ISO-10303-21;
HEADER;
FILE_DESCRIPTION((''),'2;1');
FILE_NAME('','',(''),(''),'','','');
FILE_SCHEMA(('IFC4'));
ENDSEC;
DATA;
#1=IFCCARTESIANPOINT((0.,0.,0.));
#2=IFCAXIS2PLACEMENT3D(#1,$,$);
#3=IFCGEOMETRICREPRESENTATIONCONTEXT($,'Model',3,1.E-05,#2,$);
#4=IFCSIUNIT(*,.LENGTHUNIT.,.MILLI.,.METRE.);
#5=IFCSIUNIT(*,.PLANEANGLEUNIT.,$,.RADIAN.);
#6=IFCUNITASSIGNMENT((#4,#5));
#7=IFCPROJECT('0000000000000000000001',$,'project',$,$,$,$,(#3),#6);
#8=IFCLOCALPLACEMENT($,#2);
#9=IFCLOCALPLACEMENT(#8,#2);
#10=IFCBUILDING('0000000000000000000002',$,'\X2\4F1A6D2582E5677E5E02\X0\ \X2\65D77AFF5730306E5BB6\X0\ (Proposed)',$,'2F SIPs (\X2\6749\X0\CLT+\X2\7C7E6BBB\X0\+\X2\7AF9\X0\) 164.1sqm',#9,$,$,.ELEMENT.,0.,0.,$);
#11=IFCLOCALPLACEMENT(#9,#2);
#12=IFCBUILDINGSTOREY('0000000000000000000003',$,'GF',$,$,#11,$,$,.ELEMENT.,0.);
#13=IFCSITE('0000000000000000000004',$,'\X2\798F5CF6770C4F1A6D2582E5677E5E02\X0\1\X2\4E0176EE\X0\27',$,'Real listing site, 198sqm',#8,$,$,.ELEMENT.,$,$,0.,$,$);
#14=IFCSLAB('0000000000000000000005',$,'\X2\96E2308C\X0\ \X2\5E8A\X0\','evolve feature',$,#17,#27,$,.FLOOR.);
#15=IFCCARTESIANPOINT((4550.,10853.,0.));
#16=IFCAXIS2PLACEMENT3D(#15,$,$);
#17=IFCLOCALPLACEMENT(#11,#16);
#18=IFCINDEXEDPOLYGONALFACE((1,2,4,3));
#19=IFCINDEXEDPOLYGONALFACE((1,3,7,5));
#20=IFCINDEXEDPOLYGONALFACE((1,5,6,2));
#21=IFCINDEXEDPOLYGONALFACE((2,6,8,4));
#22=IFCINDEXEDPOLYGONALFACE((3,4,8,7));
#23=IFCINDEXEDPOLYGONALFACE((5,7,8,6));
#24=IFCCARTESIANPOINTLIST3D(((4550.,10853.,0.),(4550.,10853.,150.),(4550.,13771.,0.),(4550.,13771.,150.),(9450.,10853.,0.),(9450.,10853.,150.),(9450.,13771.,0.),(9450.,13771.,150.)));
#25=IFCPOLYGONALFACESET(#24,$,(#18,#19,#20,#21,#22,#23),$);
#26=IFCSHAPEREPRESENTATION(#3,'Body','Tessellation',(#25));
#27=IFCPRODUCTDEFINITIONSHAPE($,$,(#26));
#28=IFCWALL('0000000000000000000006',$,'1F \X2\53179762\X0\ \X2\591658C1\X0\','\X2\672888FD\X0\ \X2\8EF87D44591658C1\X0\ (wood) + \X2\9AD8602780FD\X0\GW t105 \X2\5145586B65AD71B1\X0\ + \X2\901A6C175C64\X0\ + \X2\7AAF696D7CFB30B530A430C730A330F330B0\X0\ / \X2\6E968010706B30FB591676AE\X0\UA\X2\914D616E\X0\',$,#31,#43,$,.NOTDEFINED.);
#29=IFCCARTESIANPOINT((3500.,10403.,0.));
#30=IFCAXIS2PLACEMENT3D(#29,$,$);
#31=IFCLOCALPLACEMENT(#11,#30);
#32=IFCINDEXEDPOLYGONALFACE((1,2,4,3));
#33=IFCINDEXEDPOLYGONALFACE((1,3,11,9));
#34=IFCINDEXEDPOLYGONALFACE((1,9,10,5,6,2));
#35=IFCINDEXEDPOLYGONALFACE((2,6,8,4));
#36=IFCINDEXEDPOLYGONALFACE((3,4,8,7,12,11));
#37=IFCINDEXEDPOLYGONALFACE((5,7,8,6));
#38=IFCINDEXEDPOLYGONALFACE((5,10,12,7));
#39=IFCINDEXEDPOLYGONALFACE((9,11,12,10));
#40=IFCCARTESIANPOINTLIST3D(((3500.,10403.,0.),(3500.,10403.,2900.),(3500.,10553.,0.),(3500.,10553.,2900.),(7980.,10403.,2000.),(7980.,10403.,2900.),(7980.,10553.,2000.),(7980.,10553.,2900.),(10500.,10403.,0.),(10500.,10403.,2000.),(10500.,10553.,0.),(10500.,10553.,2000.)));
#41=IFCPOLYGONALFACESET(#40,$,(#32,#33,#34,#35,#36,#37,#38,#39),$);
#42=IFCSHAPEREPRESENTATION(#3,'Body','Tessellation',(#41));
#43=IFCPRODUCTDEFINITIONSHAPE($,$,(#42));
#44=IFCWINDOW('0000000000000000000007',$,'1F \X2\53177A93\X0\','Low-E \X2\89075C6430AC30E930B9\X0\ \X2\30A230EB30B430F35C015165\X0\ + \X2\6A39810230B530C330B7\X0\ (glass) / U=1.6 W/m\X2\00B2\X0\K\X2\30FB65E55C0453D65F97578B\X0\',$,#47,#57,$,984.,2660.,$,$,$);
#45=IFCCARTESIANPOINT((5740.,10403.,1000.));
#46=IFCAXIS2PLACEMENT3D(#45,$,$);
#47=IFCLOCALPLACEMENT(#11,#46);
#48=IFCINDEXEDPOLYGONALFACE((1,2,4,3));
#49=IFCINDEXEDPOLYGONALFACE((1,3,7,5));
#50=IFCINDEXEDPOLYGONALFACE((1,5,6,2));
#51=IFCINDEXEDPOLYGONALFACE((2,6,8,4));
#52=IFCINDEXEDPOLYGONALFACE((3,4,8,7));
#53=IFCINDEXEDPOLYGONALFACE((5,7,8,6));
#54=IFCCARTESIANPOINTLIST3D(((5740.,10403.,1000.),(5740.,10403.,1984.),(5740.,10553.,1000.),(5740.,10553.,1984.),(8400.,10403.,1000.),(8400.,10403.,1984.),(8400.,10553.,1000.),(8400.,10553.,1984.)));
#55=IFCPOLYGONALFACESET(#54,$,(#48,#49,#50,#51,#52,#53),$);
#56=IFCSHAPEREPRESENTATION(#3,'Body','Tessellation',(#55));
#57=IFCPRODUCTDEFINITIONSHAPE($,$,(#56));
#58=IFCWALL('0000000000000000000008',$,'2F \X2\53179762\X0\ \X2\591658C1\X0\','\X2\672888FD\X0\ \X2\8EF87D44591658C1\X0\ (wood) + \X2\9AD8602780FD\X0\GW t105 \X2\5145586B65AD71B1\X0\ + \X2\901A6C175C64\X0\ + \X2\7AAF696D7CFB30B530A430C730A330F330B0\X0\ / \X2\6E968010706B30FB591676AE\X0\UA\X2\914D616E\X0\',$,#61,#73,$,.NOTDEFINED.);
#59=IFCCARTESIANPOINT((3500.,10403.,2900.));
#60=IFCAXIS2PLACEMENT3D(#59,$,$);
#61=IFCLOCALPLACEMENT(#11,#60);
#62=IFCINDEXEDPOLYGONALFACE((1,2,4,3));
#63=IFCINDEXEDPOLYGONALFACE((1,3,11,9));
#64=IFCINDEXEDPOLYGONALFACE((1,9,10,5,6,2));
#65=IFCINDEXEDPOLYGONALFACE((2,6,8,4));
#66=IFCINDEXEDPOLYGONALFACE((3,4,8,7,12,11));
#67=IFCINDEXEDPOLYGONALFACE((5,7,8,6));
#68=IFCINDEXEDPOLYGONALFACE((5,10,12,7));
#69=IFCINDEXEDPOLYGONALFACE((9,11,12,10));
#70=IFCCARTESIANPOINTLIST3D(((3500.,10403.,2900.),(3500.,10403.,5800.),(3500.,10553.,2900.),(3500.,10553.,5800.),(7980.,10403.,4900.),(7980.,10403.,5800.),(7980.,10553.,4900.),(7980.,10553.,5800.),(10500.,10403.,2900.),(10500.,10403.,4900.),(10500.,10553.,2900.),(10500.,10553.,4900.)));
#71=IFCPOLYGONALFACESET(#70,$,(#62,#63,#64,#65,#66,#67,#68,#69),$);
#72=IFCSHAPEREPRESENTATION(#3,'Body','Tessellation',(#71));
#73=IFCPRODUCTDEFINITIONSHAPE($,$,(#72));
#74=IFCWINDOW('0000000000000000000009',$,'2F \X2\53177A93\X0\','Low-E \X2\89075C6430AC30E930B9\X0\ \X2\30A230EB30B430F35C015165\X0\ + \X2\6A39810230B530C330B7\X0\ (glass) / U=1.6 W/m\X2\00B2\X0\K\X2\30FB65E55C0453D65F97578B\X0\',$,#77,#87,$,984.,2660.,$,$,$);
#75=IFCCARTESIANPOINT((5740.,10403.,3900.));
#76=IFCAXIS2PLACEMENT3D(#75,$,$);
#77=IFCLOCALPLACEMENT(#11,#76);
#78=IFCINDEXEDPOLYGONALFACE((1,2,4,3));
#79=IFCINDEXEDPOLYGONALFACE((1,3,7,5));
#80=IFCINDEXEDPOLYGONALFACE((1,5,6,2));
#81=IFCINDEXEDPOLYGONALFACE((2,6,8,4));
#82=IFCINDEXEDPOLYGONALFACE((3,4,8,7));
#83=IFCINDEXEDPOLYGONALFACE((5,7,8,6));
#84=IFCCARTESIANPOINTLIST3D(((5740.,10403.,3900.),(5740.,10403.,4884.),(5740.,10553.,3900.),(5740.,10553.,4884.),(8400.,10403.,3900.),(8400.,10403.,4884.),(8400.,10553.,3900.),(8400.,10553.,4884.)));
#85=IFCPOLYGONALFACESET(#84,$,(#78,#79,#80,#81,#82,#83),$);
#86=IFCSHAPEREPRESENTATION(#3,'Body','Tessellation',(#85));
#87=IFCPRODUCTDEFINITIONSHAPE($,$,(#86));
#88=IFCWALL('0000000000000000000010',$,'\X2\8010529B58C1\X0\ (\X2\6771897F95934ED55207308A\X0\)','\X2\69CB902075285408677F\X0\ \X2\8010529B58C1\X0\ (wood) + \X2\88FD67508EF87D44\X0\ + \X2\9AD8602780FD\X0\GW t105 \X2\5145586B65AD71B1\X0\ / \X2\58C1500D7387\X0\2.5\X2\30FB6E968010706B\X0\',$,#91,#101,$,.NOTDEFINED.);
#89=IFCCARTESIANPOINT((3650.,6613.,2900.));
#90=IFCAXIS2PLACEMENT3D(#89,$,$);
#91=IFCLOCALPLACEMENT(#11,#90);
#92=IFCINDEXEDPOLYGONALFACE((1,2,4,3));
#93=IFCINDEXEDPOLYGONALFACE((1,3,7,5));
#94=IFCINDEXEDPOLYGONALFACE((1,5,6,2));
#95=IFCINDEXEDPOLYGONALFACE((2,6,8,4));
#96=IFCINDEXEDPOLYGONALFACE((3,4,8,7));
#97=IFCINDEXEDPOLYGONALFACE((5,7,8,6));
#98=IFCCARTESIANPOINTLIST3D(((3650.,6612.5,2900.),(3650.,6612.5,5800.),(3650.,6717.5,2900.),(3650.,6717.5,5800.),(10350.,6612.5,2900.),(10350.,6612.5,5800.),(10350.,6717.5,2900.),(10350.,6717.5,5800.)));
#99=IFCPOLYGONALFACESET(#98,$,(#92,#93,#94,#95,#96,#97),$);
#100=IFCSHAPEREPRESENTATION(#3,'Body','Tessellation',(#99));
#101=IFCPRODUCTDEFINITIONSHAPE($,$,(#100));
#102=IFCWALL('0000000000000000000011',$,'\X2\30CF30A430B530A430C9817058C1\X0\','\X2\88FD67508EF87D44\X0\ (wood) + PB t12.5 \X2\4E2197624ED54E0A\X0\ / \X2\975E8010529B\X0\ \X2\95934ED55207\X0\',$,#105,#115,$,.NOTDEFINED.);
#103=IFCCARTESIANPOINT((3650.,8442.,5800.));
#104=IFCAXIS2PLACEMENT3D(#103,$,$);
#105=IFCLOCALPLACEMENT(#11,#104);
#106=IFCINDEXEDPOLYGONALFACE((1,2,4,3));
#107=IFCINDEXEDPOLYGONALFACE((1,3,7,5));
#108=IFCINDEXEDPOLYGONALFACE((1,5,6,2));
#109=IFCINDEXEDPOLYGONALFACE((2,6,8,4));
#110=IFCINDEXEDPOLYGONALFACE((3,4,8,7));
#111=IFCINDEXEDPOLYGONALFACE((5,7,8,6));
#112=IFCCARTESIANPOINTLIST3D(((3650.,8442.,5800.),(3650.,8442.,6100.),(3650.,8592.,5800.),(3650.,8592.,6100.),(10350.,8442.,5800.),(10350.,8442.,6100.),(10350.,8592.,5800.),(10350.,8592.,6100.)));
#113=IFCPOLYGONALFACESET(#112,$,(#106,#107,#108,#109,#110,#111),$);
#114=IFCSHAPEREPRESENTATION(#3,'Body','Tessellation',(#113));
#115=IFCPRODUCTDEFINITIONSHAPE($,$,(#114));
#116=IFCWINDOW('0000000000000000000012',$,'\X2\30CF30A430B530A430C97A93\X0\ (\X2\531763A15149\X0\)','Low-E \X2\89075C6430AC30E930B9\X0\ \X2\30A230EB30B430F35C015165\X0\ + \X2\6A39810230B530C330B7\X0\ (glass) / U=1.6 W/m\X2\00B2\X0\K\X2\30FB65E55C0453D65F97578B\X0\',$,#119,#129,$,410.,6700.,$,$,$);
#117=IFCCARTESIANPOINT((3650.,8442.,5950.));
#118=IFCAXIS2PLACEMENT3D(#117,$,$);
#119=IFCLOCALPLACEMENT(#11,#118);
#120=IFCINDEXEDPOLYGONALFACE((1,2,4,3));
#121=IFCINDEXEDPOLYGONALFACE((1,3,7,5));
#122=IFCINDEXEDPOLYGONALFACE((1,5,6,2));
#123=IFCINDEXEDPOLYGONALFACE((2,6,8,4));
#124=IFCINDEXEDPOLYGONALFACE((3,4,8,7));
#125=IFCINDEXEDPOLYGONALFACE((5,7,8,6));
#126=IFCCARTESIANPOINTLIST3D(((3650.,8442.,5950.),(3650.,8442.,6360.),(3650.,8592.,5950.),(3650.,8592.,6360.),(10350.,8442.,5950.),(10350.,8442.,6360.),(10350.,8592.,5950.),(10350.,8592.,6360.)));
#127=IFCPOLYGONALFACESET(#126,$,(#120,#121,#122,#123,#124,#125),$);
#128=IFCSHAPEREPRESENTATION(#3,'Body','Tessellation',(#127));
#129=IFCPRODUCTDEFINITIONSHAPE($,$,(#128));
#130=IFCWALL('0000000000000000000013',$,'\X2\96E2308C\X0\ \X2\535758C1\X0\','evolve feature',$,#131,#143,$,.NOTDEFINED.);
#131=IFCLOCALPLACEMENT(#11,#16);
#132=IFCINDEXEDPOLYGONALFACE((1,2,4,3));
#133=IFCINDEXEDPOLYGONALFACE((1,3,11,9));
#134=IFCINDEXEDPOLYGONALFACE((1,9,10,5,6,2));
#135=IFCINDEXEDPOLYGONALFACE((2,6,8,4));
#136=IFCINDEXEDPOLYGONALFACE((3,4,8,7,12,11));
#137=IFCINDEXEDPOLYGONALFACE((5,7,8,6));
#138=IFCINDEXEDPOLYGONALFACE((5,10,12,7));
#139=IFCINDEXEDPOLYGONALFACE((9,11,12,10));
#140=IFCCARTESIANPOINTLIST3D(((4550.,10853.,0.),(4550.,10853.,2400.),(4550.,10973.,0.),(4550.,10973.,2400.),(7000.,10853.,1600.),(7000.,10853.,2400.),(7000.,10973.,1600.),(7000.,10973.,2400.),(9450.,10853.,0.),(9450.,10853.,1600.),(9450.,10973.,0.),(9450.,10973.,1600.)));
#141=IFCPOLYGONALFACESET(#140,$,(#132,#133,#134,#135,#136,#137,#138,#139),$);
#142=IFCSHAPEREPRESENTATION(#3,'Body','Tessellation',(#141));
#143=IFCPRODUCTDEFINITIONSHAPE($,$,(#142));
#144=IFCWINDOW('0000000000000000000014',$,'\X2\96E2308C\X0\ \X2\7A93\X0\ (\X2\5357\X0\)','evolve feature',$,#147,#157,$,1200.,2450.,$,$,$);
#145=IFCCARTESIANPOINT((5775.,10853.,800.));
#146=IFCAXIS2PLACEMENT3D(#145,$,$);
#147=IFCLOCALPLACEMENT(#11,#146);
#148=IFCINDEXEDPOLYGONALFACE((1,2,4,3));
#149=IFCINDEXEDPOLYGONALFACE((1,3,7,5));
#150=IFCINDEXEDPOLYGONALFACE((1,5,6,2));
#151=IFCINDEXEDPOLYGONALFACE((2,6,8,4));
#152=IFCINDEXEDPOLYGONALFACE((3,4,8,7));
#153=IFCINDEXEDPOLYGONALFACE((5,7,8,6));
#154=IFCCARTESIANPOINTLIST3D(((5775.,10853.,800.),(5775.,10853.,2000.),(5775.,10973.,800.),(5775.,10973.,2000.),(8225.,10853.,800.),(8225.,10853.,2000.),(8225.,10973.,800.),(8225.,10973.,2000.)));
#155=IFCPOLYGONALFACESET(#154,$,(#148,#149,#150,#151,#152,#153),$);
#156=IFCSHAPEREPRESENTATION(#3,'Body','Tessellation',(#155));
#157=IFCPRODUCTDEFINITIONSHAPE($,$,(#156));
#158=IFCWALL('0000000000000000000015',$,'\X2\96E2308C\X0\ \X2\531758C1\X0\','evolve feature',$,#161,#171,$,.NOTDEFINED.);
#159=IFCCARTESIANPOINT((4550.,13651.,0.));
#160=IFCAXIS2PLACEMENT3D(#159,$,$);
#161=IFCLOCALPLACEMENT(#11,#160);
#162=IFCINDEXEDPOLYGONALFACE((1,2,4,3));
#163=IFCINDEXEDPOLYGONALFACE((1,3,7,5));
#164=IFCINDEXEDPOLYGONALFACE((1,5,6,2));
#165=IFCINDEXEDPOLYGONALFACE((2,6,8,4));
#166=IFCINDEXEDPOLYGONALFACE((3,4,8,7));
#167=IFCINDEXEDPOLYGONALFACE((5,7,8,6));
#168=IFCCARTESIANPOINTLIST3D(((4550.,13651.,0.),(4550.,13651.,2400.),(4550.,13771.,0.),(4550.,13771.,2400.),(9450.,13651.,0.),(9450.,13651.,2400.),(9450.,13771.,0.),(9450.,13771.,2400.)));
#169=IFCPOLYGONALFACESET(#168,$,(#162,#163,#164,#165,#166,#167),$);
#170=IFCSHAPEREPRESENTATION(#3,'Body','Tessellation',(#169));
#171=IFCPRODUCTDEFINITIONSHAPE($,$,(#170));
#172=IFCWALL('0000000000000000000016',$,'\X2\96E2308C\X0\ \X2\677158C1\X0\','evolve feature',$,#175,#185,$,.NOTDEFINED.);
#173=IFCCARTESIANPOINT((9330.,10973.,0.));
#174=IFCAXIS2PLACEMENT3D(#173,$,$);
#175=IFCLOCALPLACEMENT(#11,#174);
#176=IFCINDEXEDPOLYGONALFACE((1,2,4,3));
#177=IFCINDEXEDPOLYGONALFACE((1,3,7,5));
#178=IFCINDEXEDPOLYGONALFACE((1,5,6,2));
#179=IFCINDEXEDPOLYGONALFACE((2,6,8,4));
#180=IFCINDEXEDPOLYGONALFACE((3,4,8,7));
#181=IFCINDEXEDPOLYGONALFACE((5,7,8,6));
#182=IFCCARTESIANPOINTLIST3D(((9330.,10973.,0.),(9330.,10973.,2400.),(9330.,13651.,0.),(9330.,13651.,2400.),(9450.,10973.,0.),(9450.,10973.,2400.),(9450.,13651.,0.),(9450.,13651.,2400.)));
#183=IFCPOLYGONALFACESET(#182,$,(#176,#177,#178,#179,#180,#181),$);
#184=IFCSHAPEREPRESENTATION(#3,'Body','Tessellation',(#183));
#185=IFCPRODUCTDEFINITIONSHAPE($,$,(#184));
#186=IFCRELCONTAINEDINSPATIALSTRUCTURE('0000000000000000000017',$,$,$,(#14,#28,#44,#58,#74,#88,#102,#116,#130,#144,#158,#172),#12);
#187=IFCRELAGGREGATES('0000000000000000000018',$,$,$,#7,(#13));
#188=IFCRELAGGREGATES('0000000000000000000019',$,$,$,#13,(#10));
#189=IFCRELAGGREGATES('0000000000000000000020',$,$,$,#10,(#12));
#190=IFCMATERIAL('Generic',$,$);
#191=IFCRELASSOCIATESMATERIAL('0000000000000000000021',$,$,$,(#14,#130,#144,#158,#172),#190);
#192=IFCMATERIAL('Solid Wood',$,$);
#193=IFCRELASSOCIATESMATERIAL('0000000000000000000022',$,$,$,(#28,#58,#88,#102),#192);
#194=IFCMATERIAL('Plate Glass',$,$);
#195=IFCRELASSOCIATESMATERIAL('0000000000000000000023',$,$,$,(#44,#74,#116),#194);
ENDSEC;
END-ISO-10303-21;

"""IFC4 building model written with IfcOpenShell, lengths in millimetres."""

from ifc_helpers import new_model, si_unit, frame, frame_2d, origin, place, context, project, spatial, rectangle, extrude, material, element, fill, save


model = new_model("IFC4")

# Units and contexts
model_context = context("Model", 3, precision=1e-05, world=origin())
ifc_project = project(units=[si_unit("LENGTHUNIT", "METRE", prefix="MILLI"), si_unit("PLANEANGLEUNIT", "RADIAN")], contexts=[model_context])

# Site, building, storey
site_placement = place(None, origin())
site = spatial("IfcSite", under=ifc_project, at=site_placement, Name="福島県会津若松市1丁目27", ObjectType="Real listing site, 198sqm", CompositionType="ELEMENT", RefElevation=0.0)
building_placement = place(site_placement, origin())
building = spatial("IfcBuilding", under=site, at=building_placement, Name="会津若松市 旗竿地の家 (Proposed)", ObjectType="2F SIPs (杉CLT+籾殻+竹) 164.1sqm", CompositionType="ELEMENT", ElevationOfRefHeight=0.0, ElevationOfTerrain=0.0)
storey_placement = place(building_placement, origin())
storey = spatial("IfcBuildingStorey", under=building, at=storey_placement, Name="GF", CompositionType="ELEMENT", Elevation=0.0)

# Slab
ifc_material_1 = material(Name="Generic")
slab_placement = place(storey_placement, frame((4550.0, 10853.0, 0.0)))
element("IfcSlab", 1, at=slab_placement, inside=storey, material=ifc_material_1, Name="離れ 床", Description="evolve feature", PredefinedType="FLOOR", context=model_context, shape_type="SweptSolid", body=[
    extrude(rectangle(XDim=4900.0, YDim=2918.0, at=frame_2d((2450.0, 1459.0))), frame((4550.0, 10853.0, 0.0)), (0.0, 0.0, 1.0), 150.0),
])

# Wall, opening, window
ifc_material_2 = material(Name="Solid Wood")
wall_1_placement = place(storey_placement, frame((3500.0, 10403.0, 0.0)))
wall_1 = element("IfcWall", 2, at=wall_1_placement, inside=storey, material=ifc_material_2, Name="1F 北面 外壁", Description="木製 軸組外壁 (wood) + 高性能GW t105 充填断熱 + 通気層 + 窯業系サイディング / 準耐火・外皮UA配慮", PredefinedType="NOTDEFINED", context=model_context, shape_type="SweptSolid", body=[
    extrude(rectangle(XDim=7000.0, YDim=150.0, at=frame_2d((3500.0, 75.0))), frame((3500.0, 10403.0, 0.0)), (0.0, 0.0, 1.0), 2900.0),
])
opening_1_placement = place(storey_placement, frame((5740.0, 10403.0, 1000.0)))
opening_1 = element("IfcOpeningElement", 3, at=opening_1_placement, cuts=wall_1, PredefinedType="NOTDEFINED", context=model_context, shape_type="SweptSolid", body=[
    extrude(rectangle(XDim=2660.0, YDim=150.0, at=frame_2d((1330.0, 75.0))), frame((5740.0, 10403.0, 1000.0)), (0.0, 0.0, 1.0), 984.0),
])
ifc_material_3 = material(Name="Plate Glass")
window_1_placement = place(storey_placement, frame((5740.0, 10403.0, 1000.0)))
window_1 = element("IfcWindow", 4, at=window_1_placement, inside=storey, material=ifc_material_3, Name="1F 北窓", Description="Low-E 複層ガラス アルゴン封入 + 樹脂サッシ (glass) / U=1.6 W/m²K・日射取得型", OverallHeight=984.0, OverallWidth=2660.0, context=model_context, shape_type="SweptSolid", body=[
    extrude(rectangle(XDim=2660.0, YDim=150.0, at=frame_2d((1330.0, 75.0))), frame((5740.0, 10403.0, 1000.0)), (0.0, 0.0, 1.0), 984.0),
])
fill(opening_1, window_1)

# Wall, opening, window
wall_2_placement = place(storey_placement, frame((3500.0, 10403.0, 2900.0)))
wall_2 = element("IfcWall", 5, at=wall_2_placement, inside=storey, material=ifc_material_2, Name="2F 北面 外壁", Description="木製 軸組外壁 (wood) + 高性能GW t105 充填断熱 + 通気層 + 窯業系サイディング / 準耐火・外皮UA配慮", PredefinedType="NOTDEFINED", context=model_context, shape_type="SweptSolid", body=[
    extrude(rectangle(XDim=7000.0, YDim=150.0, at=frame_2d((3500.0, 75.0))), frame((3500.0, 10403.0, 2900.0)), (0.0, 0.0, 1.0), 2900.0),
])
opening_2_placement = place(storey_placement, frame((5740.0, 10403.0, 3900.0)))
opening_2 = element("IfcOpeningElement", 6, at=opening_2_placement, cuts=wall_2, PredefinedType="NOTDEFINED", context=model_context, shape_type="SweptSolid", body=[
    extrude(rectangle(XDim=2660.0, YDim=150.0, at=frame_2d((1330.0, 75.0))), frame((5740.0, 10403.0, 3900.0)), (0.0, 0.0, 1.0), 984.0),
])
window_2_placement = place(storey_placement, frame((5740.0, 10403.0, 3900.0)))
window_2 = element("IfcWindow", 7, at=window_2_placement, inside=storey, material=ifc_material_3, Name="2F 北窓", Description="Low-E 複層ガラス アルゴン封入 + 樹脂サッシ (glass) / U=1.6 W/m²K・日射取得型", OverallHeight=984.0, OverallWidth=2660.0, context=model_context, shape_type="SweptSolid", body=[
    extrude(rectangle(XDim=2660.0, YDim=150.0, at=frame_2d((1330.0, 75.0))), frame((5740.0, 10403.0, 3900.0)), (0.0, 0.0, 1.0), 984.0),
])
fill(opening_2, window_2)

# Wall
wall_3_placement = place(storey_placement, frame((3650.0, 6613.0, 2900.0)))
element("IfcWall", 8, at=wall_3_placement, inside=storey, material=ifc_material_2, Name="耐力壁 (東西間仕切り)", Description="構造用合板 耐力壁 (wood) + 製材軸組 + 高性能GW t105 充填断熱 / 壁倍率2.5・準耐火", PredefinedType="NOTDEFINED", context=model_context, shape_type="SweptSolid", body=[
    extrude(rectangle(XDim=6700.0, YDim=105.0, at=frame_2d((3350.0, 52.0))), frame((3650.0, 6613.0, 2900.0)), (0.0, 0.0, 1.0), 2900.0),
])

# Walls, openings, windows
wall_4_placement = place(storey_placement, frame((3650.0, 8442.0, 5800.0)))
wall_4 = element("IfcWall", 9, at=wall_4_placement, inside=storey, material=ifc_material_2, Name="ハイサイド腰壁", Description="製材軸組 (wood) + PB t12.5 両面仕上 / 非耐力 間仕切", PredefinedType="NOTDEFINED", context=model_context, shape_type="SweptSolid", body=[
    extrude(rectangle(XDim=6700.0, YDim=150.0, at=frame_2d((3350.0, 75.0))), frame((3650.0, 8442.0, 5800.0)), (0.0, 0.0, 1.0), 700.0),
])
opening_3_placement = place(storey_placement, frame((3650.0, 8442.0, 5950.0)))
opening_3 = element("IfcOpeningElement", 10, at=opening_3_placement, cuts=wall_4, PredefinedType="NOTDEFINED", context=model_context, shape_type="SweptSolid", body=[
    extrude(rectangle(XDim=6700.0, YDim=150.0, at=frame_2d((3350.0, 75.0))), frame((3650.0, 8442.0, 5950.0)), (0.0, 0.0, 1.0), 410.0),
])
window_3_placement = place(storey_placement, frame((3650.0, 8442.0, 5950.0)))
window_3 = element("IfcWindow", 11, at=window_3_placement, inside=storey, material=ifc_material_3, Name="ハイサイド窓 (北採光)", Description="Low-E 複層ガラス アルゴン封入 + 樹脂サッシ (glass) / U=1.6 W/m²K・日射取得型", OverallHeight=410.0, OverallWidth=6700.0, context=model_context, shape_type="SweptSolid", body=[
    extrude(rectangle(XDim=6700.0, YDim=150.0, at=frame_2d((3350.0, 75.0))), frame((3650.0, 8442.0, 5950.0)), (0.0, 0.0, 1.0), 410.0),
])
fill(opening_3, window_3)
wall_5_placement = place(storey_placement, frame((4550.0, 10853.0, 0.0)))
wall_5 = element("IfcWall", 12, at=wall_5_placement, inside=storey, material=ifc_material_1, Name="離れ 南壁", Description="evolve feature", PredefinedType="NOTDEFINED", context=model_context, shape_type="SweptSolid", body=[
    extrude(rectangle(XDim=4900.0, YDim=120.0, at=frame_2d((2450.0, 60.0))), frame((4550.0, 10853.0, 0.0)), (0.0, 0.0, 1.0), 2400.0),
])
opening_4_placement = place(storey_placement, frame((5775.0, 10853.0, 800.0)))
opening_4 = element("IfcOpeningElement", 13, at=opening_4_placement, cuts=wall_5, PredefinedType="NOTDEFINED", context=model_context, shape_type="SweptSolid", body=[
    extrude(rectangle(XDim=2450.0, YDim=120.0, at=frame_2d((1225.0, 60.0))), frame((5775.0, 10853.0, 800.0)), (0.0, 0.0, 1.0), 1200.0),
])
window_4_placement = place(storey_placement, frame((5775.0, 10853.0, 800.0)))
window_4 = element("IfcWindow", 14, at=window_4_placement, inside=storey, material=ifc_material_1, Name="離れ 窓 (南)", Description="evolve feature", OverallHeight=1200.0, OverallWidth=2450.0, context=model_context, shape_type="SweptSolid", body=[
    extrude(rectangle(XDim=2450.0, YDim=120.0, at=frame_2d((1225.0, 60.0))), frame((5775.0, 10853.0, 800.0)), (0.0, 0.0, 1.0), 1200.0),
])
fill(opening_4, window_4)

# Walls
wall_6_placement = place(storey_placement, frame((4550.0, 13651.0, 0.0)))
element("IfcWall", 15, at=wall_6_placement, inside=storey, material=ifc_material_1, Name="離れ 北壁", Description="evolve feature", PredefinedType="NOTDEFINED", context=model_context, shape_type="SweptSolid", body=[
    extrude(rectangle(XDim=4900.0, YDim=120.0, at=frame_2d((2450.0, 60.0))), frame((4550.0, 13651.0, 0.0)), (0.0, 0.0, 1.0), 2400.0),
])
wall_7_placement = place(storey_placement, frame((9330.0, 10973.0, 0.0)))
element("IfcWall", 16, at=wall_7_placement, inside=storey, material=ifc_material_1, Name="離れ 東壁", Description="evolve feature", PredefinedType="NOTDEFINED", context=model_context, shape_type="SweptSolid", body=[
    extrude(rectangle(XDim=120.0, YDim=2678.0, at=frame_2d((60.0, 1339.0))), frame((9330.0, 10973.0, 0.0)), (0.0, 0.0, 1.0), 2400.0),
])

save(model, "model.ifc")
